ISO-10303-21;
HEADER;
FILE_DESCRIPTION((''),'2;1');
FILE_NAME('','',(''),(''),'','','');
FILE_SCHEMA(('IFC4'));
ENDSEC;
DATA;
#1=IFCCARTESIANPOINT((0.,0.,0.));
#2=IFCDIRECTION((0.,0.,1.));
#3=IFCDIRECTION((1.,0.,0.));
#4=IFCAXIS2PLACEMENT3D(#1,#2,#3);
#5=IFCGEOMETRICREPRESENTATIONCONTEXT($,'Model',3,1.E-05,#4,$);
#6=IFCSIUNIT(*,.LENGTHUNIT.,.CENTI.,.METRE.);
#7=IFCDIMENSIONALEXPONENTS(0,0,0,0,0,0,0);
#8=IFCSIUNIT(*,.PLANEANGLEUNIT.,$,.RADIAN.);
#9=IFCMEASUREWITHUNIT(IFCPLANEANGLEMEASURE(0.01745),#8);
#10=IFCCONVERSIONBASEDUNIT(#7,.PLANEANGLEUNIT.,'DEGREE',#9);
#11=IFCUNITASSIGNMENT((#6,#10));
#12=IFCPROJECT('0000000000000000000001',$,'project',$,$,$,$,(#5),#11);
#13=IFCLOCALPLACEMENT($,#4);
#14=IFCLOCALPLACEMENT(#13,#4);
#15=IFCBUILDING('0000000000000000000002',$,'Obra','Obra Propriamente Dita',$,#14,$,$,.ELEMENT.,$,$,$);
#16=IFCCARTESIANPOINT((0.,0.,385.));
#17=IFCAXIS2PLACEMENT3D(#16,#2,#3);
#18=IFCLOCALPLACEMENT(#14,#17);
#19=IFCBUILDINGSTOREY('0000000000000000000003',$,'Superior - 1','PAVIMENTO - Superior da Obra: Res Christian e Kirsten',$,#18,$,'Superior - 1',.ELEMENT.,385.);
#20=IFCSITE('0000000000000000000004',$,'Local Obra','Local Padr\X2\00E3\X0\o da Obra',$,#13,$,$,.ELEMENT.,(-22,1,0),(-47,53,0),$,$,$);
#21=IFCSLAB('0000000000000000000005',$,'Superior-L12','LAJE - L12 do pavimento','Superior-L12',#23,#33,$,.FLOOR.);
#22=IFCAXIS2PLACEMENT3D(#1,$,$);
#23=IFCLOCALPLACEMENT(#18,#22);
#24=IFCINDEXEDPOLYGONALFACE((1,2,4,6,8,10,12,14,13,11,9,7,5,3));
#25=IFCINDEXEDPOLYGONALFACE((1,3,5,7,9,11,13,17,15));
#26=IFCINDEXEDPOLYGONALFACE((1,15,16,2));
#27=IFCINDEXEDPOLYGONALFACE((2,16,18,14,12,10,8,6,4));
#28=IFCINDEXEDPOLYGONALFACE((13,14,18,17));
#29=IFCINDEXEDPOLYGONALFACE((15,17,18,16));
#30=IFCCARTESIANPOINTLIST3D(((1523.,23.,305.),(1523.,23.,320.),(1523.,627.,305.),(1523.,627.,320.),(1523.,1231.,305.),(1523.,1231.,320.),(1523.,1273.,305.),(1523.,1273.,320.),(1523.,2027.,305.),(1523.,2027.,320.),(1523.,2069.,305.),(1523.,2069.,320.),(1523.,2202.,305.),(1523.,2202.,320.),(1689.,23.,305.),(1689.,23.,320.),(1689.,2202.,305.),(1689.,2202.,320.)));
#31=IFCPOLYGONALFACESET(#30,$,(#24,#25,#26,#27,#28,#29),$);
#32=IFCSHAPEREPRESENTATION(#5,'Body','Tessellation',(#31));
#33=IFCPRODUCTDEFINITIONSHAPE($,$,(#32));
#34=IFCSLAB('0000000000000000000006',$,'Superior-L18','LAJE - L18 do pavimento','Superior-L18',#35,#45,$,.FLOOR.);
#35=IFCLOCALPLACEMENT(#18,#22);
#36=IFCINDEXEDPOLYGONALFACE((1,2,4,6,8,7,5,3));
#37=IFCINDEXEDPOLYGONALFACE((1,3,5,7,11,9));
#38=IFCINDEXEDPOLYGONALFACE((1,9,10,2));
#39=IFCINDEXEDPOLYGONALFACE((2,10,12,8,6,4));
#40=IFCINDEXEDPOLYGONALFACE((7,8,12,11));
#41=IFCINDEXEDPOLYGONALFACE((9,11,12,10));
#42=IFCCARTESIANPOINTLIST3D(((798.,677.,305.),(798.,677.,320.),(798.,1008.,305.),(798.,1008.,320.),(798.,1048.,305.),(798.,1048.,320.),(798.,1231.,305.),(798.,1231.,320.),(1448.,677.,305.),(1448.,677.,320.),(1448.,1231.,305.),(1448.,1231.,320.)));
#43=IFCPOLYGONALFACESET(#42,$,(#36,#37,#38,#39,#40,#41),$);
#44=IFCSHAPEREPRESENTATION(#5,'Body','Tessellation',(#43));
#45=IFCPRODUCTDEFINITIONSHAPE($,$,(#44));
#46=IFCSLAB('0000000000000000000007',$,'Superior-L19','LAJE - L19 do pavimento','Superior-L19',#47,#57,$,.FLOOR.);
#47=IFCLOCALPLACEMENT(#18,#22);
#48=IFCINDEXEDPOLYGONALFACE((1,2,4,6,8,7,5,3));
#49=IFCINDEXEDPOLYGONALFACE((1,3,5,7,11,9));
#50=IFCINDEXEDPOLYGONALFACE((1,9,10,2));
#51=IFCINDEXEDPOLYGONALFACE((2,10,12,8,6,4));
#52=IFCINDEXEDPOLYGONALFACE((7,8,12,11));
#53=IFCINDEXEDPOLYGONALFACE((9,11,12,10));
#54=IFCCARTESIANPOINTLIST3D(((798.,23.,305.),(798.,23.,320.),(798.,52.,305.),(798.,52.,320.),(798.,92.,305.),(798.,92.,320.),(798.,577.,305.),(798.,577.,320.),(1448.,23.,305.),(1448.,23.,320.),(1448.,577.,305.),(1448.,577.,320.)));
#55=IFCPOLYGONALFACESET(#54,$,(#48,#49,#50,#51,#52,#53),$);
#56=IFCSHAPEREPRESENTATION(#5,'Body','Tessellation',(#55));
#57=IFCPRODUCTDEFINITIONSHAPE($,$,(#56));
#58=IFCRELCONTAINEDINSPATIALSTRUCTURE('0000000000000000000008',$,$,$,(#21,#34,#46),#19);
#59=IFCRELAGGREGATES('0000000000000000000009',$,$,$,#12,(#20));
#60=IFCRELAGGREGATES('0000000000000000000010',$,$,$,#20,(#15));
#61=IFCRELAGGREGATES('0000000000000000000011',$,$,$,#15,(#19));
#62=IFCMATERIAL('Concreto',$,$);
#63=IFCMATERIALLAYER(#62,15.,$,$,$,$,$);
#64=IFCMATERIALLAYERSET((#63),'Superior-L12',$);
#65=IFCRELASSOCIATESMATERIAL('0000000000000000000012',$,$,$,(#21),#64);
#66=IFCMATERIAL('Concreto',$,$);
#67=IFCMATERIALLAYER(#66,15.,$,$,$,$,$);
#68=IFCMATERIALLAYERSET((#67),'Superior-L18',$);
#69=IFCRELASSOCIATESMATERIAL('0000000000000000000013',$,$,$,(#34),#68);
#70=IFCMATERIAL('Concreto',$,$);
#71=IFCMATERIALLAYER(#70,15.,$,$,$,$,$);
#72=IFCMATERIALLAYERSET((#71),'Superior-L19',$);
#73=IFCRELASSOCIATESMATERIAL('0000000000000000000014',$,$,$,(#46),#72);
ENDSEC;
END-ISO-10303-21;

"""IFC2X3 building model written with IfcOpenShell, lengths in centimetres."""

from ifc_helpers import new_model, entity, si_unit, converted_unit, frame, origin_with_axes, place, context, project, spatial, polyline, outline, extrude, material, layer, layer_set, layer_usage, element, save


model = new_model("IFC2X3")

# Units and contexts
model_context = context("Model", 3, precision=1e-05, world=origin_with_axes())
ifc_project = project(units=[si_unit("LENGTHUNIT", "METRE", prefix="CENTI"), converted_unit("PLANEANGLEUNIT", "DEGREE", entity("IfcPlaneAngleMeasure", 0.01745), si_unit("PLANEANGLEUNIT", "RADIAN"), dimensions=[0, 0, 0, 0, 0, 0, 0])], contexts=[model_context])

# Site, building, storey
site_placement = place(None, origin_with_axes())
site = spatial("IfcSite", under=ifc_project, at=site_placement, Name="Local Obra", Description="Local Padrão da Obra", CompositionType="ELEMENT", RefLatitude=(-22, 1, 0), RefLongitude=(-47, 53, 0))
building_placement = place(site_placement, origin_with_axes())
building = spatial("IfcBuilding", under=site, at=building_placement, Name="Obra", Description="Obra Propriamente Dita", CompositionType="ELEMENT")
storey_placement = place(building_placement, frame((0.0, 0.0, 385.0), z_axis=(0.0, 0.0, 1.0), x_axis=(1.0, 0.0, 0.0)))
storey = spatial("IfcBuildingStorey", under=building, at=storey_placement, Name="Superior - 1", Description="PAVIMENTO - Superior da Obra: Res Christian e Kirsten", LongName="Superior - 1", CompositionType="ELEMENT", Elevation=385.0)

# Slabs
ifc_material_1 = material(Name="Concreto")
ifc_layer_1 = layer(ifc_material_1, 15.0)
ifc_layer_set_1 = layer_set([ifc_layer_1], Name="Superior-L12")
ifc_layer_usage_1 = layer_usage(ifc_layer_set_1, "AXIS3", "POSITIVE", 0.0)
slab_1_placement = place(storey_placement, frame((1689.0, 23.0, 305.0), z_axis=(0.0, 0.0, 1.0), x_axis=(1.0, 0.0, 0.0)))
element("IfcSlab", 1, at=slab_1_placement, inside=storey, material=ifc_layer_usage_1, Name="Superior-L12", Description="LAJE - L12 do pavimento", ObjectType="Superior-L12", PredefinedType="FLOOR", context=model_context, shape_type="SweptSolid", body=[
    extrude(outline(polyline([(0.0, 2179.0), (-166.0, 2179.0), (-166.0, 2046.0), (-166.0, 2004.0), (-166.0, 1250.0), (-166.0, 1208.0), (-166.0, 604.0), (-166.0, 0.0), (0.0, 0.0), (0.0, 2179.0)])), origin_with_axes(), (0.0, 0.0, 1.0), 15.0),
])
ifc_material_2 = material(Name="Concreto")
ifc_layer_2 = layer(ifc_material_2, 15.0)
ifc_layer_set_2 = layer_set([ifc_layer_2], Name="Superior-L18")
ifc_layer_usage_2 = layer_usage(ifc_layer_set_2, "AXIS3", "POSITIVE", 0.0)
slab_2_placement = place(storey_placement, frame((1448.0, 677.0, 305.0), z_axis=(0.0, 0.0, 1.0), x_axis=(1.0, 0.0, 0.0)))
element("IfcSlab", 2, at=slab_2_placement, inside=storey, material=ifc_layer_usage_2, Name="Superior-L18", Description="LAJE - L18 do pavimento", ObjectType="Superior-L18", PredefinedType="FLOOR", context=model_context, shape_type="SweptSolid", body=[
    extrude(outline(polyline([(0.0, 554.0), (-650.0, 554.0), (-650.0, 371.0), (-650.0, 331.0), (-650.0, 0.0), (0.0, 0.0), (0.0, 554.0)])), origin_with_axes(), (0.0, 0.0, 1.0), 15.0),
])
ifc_material_3 = material(Name="Concreto")
ifc_layer_3 = layer(ifc_material_3, 15.0)
ifc_layer_set_3 = layer_set([ifc_layer_3], Name="Superior-L19")
ifc_layer_usage_3 = layer_usage(ifc_layer_set_3, "AXIS3", "POSITIVE", 0.0)
slab_3_placement = place(storey_placement, frame((1448.0, 23.0, 305.0), z_axis=(0.0, 0.0, 1.0), x_axis=(1.0, 0.0, 0.0)))
element("IfcSlab", 3, at=slab_3_placement, inside=storey, material=ifc_layer_usage_3, Name="Superior-L19", Description="LAJE - L19 do pavimento", ObjectType="Superior-L19", PredefinedType="FLOOR", context=model_context, shape_type="SweptSolid", body=[
    extrude(outline(polyline([(0.0, 554.0), (-650.0, 554.0), (-650.0, 69.0), (-650.0, 29.0), (-650.0, 0.0), (0.0, 0.0), (0.0, 554.0)])), origin_with_axes(), (0.0, 0.0, 1.0), 15.0),
])

save(model, "model.ifc")
